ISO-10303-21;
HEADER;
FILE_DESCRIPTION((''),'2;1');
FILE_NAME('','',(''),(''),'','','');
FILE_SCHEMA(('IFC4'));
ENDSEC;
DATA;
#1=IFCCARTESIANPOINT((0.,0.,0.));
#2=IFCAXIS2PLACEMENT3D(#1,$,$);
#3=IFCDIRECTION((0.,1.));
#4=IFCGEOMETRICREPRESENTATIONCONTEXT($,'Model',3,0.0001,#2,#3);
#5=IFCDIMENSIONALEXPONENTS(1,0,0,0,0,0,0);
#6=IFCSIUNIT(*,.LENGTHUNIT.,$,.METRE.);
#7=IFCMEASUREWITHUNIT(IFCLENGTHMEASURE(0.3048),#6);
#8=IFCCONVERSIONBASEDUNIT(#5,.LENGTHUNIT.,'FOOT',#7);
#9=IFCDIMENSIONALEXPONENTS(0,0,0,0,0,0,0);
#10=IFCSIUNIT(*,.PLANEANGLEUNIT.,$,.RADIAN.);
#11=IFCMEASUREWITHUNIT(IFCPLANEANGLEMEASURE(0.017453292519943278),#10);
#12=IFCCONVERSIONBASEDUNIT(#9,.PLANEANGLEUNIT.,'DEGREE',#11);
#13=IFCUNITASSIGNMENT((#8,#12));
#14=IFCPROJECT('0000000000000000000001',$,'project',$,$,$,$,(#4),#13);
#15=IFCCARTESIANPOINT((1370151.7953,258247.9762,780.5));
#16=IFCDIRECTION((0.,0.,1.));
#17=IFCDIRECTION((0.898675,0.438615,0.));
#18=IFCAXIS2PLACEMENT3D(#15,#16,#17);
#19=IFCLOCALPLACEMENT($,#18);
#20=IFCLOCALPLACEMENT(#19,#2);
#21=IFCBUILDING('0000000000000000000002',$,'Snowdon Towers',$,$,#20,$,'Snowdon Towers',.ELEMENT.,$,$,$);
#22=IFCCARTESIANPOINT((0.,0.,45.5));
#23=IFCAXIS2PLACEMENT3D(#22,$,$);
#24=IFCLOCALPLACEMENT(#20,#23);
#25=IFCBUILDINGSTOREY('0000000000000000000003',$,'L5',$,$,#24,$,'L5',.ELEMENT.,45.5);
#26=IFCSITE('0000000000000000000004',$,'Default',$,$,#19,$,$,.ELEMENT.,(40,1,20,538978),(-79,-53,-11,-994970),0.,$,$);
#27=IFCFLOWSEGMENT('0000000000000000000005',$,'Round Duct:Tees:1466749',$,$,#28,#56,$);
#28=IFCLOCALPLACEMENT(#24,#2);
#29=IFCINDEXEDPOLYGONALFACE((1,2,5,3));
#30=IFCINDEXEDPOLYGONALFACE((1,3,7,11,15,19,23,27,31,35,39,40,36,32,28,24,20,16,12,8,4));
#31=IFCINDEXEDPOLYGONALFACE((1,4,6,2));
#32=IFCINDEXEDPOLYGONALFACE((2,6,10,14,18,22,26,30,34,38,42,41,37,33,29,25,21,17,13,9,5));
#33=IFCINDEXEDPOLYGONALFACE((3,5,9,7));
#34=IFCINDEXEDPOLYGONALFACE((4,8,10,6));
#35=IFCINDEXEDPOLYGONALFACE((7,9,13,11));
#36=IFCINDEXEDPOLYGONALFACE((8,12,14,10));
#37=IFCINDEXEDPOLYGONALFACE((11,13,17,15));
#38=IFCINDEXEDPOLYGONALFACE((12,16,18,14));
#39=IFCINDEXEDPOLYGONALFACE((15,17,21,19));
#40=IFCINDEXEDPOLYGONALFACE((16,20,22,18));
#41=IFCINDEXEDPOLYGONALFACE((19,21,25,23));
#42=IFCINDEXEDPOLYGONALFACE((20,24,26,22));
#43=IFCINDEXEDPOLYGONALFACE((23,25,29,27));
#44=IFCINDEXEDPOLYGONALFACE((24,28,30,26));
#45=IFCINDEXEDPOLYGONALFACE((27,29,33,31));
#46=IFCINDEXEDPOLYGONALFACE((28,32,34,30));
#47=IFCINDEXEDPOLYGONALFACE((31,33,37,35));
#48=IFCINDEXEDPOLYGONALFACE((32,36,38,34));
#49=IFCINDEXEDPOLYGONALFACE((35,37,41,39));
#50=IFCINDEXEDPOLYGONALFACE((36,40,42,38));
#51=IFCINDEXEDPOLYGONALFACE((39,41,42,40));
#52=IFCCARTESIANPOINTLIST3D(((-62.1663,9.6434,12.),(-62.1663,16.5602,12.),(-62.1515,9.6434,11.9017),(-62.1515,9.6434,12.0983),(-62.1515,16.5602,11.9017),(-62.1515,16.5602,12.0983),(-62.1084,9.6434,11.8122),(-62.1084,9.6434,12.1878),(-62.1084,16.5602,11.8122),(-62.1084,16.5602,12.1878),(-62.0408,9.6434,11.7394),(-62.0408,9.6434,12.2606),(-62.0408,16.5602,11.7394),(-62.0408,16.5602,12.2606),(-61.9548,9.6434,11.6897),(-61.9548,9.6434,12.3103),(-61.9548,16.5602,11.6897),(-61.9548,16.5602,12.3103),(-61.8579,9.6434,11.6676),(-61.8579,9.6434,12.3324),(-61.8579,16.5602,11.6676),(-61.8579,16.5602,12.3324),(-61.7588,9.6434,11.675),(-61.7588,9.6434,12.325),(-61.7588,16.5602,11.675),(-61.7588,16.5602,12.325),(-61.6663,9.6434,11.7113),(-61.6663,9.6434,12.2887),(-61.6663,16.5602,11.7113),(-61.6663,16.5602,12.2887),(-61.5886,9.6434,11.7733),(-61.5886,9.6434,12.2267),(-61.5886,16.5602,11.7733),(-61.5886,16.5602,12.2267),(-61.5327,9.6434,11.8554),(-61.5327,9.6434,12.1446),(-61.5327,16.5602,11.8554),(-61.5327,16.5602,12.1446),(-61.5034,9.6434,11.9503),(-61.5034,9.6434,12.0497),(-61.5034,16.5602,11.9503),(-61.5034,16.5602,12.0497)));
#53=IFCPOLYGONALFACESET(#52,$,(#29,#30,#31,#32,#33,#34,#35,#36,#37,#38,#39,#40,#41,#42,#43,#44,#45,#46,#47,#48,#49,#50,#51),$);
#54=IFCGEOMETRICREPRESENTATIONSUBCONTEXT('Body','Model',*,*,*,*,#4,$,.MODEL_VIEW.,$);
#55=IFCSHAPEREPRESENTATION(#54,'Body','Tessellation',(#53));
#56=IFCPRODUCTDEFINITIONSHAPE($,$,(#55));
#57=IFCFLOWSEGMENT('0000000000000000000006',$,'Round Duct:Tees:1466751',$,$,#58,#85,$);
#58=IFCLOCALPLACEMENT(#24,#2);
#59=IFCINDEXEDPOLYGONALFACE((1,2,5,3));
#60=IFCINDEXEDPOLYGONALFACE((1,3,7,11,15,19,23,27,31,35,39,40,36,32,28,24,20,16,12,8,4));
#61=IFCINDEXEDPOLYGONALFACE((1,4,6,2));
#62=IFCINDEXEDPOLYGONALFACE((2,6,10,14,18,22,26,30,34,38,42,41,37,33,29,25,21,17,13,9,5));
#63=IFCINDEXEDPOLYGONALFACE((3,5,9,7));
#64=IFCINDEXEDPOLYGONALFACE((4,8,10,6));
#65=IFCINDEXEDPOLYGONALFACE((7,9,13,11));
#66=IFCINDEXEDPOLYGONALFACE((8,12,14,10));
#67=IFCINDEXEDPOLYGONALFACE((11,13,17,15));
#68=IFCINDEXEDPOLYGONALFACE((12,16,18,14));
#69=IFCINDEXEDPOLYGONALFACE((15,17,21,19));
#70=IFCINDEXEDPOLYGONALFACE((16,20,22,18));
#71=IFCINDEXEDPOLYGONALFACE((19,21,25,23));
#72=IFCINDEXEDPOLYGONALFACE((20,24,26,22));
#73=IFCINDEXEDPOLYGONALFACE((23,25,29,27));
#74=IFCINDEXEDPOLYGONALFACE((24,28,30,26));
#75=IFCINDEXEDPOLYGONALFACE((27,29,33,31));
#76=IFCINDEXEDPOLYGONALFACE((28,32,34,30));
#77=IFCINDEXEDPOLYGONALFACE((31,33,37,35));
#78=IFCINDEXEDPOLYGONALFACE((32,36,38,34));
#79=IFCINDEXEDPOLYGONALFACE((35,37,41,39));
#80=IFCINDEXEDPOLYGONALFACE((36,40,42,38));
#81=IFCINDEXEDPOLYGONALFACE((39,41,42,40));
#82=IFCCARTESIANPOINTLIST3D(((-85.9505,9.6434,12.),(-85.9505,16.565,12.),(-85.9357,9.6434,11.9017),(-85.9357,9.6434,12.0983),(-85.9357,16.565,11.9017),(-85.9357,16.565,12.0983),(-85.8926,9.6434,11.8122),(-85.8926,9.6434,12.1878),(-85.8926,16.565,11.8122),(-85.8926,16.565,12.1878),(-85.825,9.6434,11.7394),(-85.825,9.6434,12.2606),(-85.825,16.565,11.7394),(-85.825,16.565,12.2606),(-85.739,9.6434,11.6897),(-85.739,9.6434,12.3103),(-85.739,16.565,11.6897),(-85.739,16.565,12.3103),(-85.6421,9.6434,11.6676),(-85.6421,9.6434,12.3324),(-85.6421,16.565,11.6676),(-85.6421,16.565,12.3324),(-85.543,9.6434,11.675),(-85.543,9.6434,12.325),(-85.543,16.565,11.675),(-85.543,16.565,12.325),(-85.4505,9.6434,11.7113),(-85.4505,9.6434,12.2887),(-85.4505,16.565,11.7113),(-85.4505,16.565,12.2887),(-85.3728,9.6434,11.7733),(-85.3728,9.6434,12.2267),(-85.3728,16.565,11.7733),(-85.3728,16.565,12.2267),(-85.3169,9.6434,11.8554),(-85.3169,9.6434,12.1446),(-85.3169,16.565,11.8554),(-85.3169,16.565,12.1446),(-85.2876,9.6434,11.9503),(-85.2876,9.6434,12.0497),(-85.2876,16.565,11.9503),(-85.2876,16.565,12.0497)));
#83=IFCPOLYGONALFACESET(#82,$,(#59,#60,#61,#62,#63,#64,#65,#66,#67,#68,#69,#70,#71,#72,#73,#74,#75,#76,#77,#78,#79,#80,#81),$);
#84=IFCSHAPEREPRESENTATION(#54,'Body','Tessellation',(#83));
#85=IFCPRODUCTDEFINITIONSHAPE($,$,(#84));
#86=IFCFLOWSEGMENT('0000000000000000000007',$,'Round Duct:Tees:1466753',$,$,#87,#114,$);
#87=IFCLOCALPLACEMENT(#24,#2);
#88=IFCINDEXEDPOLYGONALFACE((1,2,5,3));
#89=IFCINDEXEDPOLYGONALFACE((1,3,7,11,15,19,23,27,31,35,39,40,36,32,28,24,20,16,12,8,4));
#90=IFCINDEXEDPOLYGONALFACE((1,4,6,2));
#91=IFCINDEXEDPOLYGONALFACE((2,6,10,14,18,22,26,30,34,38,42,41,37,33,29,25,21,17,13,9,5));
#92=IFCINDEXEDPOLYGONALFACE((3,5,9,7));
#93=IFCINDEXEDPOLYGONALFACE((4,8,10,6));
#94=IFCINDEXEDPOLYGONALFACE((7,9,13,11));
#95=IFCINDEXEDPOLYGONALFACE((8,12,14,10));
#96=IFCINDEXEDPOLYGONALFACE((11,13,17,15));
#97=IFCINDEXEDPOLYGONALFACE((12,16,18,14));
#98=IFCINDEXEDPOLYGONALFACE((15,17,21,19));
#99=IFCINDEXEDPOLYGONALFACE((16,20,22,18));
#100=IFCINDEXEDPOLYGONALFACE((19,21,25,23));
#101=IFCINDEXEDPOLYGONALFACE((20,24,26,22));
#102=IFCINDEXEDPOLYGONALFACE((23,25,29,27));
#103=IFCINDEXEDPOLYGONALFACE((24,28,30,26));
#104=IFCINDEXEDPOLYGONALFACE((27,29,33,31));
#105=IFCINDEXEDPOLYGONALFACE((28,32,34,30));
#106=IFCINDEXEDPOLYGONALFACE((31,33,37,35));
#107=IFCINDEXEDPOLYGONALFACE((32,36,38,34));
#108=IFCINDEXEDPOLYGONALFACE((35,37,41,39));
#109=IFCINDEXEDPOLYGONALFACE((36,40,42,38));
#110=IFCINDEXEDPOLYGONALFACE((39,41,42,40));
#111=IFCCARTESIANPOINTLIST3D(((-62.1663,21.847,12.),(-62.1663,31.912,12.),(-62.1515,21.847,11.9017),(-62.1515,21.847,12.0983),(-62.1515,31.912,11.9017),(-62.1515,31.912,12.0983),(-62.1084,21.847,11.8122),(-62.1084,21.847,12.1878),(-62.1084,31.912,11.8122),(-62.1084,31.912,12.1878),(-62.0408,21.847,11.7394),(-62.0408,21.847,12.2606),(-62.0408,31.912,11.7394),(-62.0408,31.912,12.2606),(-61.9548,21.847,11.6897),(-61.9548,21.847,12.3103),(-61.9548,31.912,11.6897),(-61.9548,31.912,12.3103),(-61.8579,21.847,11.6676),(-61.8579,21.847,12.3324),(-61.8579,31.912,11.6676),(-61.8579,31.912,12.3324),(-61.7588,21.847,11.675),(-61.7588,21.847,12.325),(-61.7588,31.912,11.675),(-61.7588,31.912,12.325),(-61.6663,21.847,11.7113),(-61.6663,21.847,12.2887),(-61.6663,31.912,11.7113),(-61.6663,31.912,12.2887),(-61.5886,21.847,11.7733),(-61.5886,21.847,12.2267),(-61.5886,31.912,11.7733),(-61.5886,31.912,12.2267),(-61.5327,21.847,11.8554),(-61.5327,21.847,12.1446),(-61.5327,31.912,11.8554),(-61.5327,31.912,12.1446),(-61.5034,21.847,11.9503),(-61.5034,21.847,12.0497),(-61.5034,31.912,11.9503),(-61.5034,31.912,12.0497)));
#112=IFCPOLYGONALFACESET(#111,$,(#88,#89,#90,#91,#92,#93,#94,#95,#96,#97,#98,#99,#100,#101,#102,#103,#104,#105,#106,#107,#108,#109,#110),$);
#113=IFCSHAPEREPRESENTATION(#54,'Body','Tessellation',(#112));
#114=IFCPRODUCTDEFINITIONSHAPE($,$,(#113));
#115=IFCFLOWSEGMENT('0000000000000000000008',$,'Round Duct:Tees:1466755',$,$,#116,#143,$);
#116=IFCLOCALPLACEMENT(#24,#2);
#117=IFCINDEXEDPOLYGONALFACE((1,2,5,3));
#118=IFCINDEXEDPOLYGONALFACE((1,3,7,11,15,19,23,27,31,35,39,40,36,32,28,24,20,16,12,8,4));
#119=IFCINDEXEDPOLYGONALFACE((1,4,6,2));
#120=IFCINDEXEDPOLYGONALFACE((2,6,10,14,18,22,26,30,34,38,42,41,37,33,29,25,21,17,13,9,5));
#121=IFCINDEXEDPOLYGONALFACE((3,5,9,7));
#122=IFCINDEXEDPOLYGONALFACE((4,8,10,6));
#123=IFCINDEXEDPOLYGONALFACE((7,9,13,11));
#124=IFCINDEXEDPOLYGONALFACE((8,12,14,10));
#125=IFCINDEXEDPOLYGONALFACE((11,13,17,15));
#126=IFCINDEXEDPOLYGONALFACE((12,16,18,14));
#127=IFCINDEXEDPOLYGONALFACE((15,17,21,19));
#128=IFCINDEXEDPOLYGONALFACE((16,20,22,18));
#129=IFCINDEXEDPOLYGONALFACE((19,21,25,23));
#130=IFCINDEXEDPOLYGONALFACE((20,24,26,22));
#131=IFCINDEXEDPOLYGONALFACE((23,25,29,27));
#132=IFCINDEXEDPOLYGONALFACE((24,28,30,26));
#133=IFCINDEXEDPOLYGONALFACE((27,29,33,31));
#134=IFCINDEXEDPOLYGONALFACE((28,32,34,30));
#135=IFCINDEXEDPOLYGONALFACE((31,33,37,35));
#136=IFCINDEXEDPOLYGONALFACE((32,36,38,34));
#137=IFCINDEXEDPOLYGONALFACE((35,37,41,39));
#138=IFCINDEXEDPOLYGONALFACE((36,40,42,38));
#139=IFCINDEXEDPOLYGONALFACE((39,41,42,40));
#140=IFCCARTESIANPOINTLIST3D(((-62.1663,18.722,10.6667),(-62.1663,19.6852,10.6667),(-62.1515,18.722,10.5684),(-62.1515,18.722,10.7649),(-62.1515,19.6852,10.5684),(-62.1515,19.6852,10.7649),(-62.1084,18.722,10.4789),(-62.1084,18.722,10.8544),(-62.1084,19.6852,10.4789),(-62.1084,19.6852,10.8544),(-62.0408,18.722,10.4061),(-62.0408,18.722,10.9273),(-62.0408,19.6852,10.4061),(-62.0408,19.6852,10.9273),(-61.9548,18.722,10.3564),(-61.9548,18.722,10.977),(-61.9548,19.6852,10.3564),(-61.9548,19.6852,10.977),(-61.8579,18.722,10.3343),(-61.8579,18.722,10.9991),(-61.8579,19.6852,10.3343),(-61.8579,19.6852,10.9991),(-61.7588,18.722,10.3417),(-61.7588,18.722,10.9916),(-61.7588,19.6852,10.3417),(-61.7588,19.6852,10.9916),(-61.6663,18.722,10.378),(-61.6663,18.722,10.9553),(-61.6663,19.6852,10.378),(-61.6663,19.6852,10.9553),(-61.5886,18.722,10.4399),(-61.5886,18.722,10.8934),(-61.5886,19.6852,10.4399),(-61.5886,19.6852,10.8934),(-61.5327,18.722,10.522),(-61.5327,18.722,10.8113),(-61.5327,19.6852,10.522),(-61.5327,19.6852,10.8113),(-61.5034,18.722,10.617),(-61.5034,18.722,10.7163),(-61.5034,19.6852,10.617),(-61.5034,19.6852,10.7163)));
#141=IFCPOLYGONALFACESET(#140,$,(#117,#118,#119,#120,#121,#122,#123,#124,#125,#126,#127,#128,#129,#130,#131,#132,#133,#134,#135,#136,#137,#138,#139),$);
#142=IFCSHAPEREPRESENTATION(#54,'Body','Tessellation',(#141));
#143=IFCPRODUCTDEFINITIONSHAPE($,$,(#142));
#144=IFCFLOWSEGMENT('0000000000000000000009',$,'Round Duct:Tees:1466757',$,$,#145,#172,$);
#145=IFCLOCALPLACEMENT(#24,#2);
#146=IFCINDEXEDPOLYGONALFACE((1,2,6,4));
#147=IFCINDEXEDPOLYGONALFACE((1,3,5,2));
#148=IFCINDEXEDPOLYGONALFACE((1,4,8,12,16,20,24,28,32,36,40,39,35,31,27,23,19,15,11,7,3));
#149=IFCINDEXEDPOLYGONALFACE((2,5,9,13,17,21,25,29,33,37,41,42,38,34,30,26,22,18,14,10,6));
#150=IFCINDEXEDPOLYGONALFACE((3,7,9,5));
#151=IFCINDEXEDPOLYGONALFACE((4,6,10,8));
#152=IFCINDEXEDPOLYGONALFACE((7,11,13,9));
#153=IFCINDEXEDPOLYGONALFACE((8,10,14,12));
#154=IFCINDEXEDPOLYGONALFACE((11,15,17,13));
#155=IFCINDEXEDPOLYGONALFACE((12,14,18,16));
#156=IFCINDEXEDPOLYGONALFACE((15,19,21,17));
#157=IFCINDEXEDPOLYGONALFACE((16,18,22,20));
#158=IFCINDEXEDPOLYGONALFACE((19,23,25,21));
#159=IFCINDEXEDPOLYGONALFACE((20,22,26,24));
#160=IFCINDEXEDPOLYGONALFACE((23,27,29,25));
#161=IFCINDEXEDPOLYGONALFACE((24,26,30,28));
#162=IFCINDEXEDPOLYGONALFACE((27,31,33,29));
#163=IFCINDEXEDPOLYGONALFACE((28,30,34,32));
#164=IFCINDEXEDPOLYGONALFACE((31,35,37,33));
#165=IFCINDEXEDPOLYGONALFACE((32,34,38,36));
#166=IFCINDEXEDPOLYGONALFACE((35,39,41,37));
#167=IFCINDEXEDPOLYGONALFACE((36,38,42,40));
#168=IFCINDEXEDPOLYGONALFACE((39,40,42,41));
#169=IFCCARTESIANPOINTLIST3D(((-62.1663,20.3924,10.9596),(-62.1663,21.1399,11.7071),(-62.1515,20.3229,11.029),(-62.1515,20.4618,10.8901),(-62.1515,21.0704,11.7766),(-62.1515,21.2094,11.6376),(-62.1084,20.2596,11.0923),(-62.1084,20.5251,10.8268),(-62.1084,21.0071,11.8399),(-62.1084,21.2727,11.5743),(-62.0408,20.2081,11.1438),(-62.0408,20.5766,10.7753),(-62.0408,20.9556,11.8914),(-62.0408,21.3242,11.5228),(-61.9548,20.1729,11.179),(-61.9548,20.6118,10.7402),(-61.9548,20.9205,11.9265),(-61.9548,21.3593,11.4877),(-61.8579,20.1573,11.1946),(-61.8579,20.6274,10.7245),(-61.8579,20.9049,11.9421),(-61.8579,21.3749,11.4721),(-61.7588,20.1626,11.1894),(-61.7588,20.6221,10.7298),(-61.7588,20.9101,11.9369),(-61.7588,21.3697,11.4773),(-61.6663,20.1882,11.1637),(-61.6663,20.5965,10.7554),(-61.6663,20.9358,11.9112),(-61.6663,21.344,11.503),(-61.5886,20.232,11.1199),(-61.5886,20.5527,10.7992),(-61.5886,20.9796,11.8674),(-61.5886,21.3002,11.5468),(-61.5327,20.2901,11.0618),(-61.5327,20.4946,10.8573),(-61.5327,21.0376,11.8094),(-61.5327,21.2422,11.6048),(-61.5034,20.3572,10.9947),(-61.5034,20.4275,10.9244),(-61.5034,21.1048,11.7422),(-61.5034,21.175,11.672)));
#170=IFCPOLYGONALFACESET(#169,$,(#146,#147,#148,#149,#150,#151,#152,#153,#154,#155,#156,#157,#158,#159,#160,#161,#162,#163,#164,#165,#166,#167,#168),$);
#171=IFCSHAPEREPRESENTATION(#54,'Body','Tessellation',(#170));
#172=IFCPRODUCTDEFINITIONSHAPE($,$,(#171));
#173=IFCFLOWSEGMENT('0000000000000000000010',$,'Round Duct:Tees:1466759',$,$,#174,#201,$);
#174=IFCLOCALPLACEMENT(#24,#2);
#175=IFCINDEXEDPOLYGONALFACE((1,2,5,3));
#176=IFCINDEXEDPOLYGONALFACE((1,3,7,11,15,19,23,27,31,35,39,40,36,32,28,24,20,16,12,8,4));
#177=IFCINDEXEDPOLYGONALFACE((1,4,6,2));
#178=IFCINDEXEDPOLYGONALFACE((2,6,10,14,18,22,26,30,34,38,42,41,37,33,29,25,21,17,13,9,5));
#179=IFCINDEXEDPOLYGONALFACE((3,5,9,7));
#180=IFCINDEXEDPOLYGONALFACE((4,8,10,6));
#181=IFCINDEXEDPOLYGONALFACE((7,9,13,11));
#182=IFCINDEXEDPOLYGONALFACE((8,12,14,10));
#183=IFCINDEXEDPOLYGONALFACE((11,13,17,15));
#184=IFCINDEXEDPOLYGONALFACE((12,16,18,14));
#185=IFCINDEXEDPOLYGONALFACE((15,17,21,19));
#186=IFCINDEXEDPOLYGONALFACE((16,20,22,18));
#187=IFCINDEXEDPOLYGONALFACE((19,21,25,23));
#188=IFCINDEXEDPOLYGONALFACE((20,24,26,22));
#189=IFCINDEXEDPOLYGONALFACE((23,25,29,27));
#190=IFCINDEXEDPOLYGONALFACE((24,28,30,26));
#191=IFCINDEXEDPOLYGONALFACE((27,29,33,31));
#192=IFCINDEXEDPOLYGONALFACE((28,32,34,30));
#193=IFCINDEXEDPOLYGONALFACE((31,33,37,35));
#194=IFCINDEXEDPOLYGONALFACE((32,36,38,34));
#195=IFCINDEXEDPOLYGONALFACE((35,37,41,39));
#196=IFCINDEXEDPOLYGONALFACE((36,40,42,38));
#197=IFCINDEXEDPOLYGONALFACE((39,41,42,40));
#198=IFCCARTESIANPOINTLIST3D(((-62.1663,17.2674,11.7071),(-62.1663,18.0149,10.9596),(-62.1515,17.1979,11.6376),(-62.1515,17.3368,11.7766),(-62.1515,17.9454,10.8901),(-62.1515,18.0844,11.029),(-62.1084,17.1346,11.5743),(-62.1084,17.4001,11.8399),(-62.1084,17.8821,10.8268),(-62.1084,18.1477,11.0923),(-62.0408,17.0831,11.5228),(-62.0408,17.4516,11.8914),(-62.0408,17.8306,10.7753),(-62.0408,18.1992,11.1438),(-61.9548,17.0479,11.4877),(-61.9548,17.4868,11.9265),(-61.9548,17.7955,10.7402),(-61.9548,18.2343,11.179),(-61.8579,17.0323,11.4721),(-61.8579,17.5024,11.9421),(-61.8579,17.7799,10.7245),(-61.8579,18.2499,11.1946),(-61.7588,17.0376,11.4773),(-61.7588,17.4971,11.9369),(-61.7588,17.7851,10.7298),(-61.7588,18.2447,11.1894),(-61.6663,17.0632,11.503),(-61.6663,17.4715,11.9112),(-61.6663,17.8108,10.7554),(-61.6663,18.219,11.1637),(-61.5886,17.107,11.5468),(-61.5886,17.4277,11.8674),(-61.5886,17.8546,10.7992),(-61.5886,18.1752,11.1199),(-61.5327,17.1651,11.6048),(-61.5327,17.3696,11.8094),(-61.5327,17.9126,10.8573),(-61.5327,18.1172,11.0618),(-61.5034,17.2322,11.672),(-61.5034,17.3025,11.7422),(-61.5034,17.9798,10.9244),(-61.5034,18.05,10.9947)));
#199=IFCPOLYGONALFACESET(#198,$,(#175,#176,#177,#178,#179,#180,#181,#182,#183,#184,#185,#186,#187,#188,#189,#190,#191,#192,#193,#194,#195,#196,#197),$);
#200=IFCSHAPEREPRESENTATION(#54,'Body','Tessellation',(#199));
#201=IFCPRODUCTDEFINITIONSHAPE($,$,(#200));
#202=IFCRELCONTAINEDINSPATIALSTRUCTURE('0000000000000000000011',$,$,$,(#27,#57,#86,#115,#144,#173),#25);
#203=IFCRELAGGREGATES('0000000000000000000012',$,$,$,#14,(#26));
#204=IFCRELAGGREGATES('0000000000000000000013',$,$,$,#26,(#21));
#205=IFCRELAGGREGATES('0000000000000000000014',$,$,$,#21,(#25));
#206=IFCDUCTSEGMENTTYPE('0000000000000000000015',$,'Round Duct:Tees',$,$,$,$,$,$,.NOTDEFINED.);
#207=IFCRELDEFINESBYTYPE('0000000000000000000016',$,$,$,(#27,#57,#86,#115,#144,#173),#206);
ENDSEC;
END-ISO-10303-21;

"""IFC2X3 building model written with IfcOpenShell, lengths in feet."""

from ifc_helpers import new_model, entity, si_unit, converted_unit, direction, frame, frame_2d, origin, origin_2d_with_axis, place, context, subcontext, project, spatial, circle, extrude, type_object, element, save


model = new_model("IFC2X3")

# Units and contexts
model_context = context("Model", 3, precision=0.0001, world=origin(), true_north=direction((0.0, 1.0)))
body_context = subcontext(model_context, "Body", "Model", "MODEL_VIEW")
ifc_project = project(units=[converted_unit("LENGTHUNIT", "FOOT", entity("IfcLengthMeasure", 0.3048), si_unit("LENGTHUNIT", "METRE"), dimensions=[1, 0, 0, 0, 0, 0, 0]), converted_unit("PLANEANGLEUNIT", "DEGREE", entity("IfcPlaneAngleMeasure", 0.017453292519943278), si_unit("PLANEANGLEUNIT", "RADIAN"), dimensions=[0, 0, 0, 0, 0, 0, 0])], contexts=[model_context])

# Site, building, storey
site_placement = place(None, frame((1370151.7953, 258247.9762, 780.5), z_axis=(0.0, 0.0, 1.0), x_axis=(0.898675, 0.438615, 0.0)))
site = spatial("IfcSite", under=ifc_project, at=site_placement, Name="Default", CompositionType="ELEMENT", RefLatitude=(40, 1, 20, 538978), RefLongitude=(-79, -53, -11, -994970), RefElevation=0.0)
building_placement = place(site_placement, origin())
building = spatial("IfcBuilding", under=site, at=building_placement, Name="Snowdon Towers", LongName="Snowdon Towers", CompositionType="ELEMENT")
storey_placement = place(building_placement, frame((0.0, 0.0, 45.5)))
storey = spatial("IfcBuildingStorey", under=building, at=storey_placement, Name="L5", LongName="L5", CompositionType="ELEMENT", Elevation=45.5)

# Flow segments
duct_segment_type = type_object("IfcDuctSegmentType", Name="Round Duct:Tees", PredefinedType="NOTDEFINED")
flow_segment_1_placement = place(storey_placement, origin())
element("IfcFlowSegment", 1, at=flow_segment_1_placement, inside=storey, type_object=duct_segment_type, Name="Round Duct:Tees:1466749", context=body_context, shape_type="SweptSolid", body=[
    extrude(circle(Radius=0.3333, at=frame_2d((0.0, 0.0), x_axis=(1.0, 0.0))), frame((-61.833, 9.6434, 12.0), z_axis=(0.0, 1.0, 0.0), x_axis=(-1.0, 0.0, 0.0)), (0.0, 0.0, 1.0), 6.9169),
])
flow_segment_2_placement = place(storey_placement, origin())
element("IfcFlowSegment", 2, at=flow_segment_2_placement, inside=storey, type_object=duct_segment_type, Name="Round Duct:Tees:1466751", context=body_context, shape_type="SweptSolid", body=[
    extrude(circle(Radius=0.3333, at=frame_2d((0.0, 0.0), x_axis=(1.0, 0.0))), frame((-85.6172, 9.6434, 12.0), z_axis=(0.0, 1.0, 0.0), x_axis=(-1.0, 0.0, 0.0)), (0.0, 0.0, 1.0), 6.9216),
])
flow_segment_3_placement = place(storey_placement, origin())
element("IfcFlowSegment", 3, at=flow_segment_3_placement, inside=storey, type_object=duct_segment_type, Name="Round Duct:Tees:1466753", context=body_context, shape_type="SweptSolid", body=[
    extrude(circle(Radius=0.3333, at=frame_2d((0.0, 0.0), x_axis=(1.0, 0.0))), frame((-61.833, 21.847, 12.0), z_axis=(0.0, 1.0, 0.0), x_axis=(-1.0, 0.0, 0.0)), (0.0, 0.0, 1.0), 10.065),
])
flow_segment_4_placement = place(storey_placement, origin())
element("IfcFlowSegment", 4, at=flow_segment_4_placement, inside=storey, type_object=duct_segment_type, Name="Round Duct:Tees:1466755", context=body_context, shape_type="SweptSolid", body=[
    extrude(circle(Radius=0.3333, at=frame_2d((0.0, 0.0), x_axis=(1.0, 0.0))), frame((-61.833, 18.722, 10.6667), z_axis=(0.0, 1.0, 0.0), x_axis=(-1.0, 0.0, 0.0)), (0.0, 0.0, 1.0), 0.9632),
])
flow_segment_5_placement = place(storey_placement, origin())
element("IfcFlowSegment", 5, at=flow_segment_5_placement, inside=storey, type_object=duct_segment_type, Name="Round Duct:Tees:1466757", context=body_context, shape_type="SweptSolid", body=[
    extrude(circle(Radius=0.3333, at=frame_2d((0.0, 0.0), x_axis=(1.0, 0.0))), frame((-61.833, 20.3924, 10.9596), z_axis=(0.0, 0.707107, 0.707107), x_axis=(-1.0, 0.0, 0.0)), (0.0, 0.0, 1.0), 1.0572),
])
flow_segment_6_placement = place(storey_placement, origin())
element("IfcFlowSegment", 6, at=flow_segment_6_placement, inside=storey, type_object=duct_segment_type, Name="Round Duct:Tees:1466759", context=body_context, shape_type="SweptSolid", body=[
    extrude(circle(Radius=0.3333, at=origin_2d_with_axis()), frame((-61.833, 17.2674, 11.7071), z_axis=(0.0, 0.707107, -0.707107), x_axis=(-1.0, 0.0, 0.0)), (0.0, 0.0, 1.0), 1.0572),
])

save(model, "model.ifc")
